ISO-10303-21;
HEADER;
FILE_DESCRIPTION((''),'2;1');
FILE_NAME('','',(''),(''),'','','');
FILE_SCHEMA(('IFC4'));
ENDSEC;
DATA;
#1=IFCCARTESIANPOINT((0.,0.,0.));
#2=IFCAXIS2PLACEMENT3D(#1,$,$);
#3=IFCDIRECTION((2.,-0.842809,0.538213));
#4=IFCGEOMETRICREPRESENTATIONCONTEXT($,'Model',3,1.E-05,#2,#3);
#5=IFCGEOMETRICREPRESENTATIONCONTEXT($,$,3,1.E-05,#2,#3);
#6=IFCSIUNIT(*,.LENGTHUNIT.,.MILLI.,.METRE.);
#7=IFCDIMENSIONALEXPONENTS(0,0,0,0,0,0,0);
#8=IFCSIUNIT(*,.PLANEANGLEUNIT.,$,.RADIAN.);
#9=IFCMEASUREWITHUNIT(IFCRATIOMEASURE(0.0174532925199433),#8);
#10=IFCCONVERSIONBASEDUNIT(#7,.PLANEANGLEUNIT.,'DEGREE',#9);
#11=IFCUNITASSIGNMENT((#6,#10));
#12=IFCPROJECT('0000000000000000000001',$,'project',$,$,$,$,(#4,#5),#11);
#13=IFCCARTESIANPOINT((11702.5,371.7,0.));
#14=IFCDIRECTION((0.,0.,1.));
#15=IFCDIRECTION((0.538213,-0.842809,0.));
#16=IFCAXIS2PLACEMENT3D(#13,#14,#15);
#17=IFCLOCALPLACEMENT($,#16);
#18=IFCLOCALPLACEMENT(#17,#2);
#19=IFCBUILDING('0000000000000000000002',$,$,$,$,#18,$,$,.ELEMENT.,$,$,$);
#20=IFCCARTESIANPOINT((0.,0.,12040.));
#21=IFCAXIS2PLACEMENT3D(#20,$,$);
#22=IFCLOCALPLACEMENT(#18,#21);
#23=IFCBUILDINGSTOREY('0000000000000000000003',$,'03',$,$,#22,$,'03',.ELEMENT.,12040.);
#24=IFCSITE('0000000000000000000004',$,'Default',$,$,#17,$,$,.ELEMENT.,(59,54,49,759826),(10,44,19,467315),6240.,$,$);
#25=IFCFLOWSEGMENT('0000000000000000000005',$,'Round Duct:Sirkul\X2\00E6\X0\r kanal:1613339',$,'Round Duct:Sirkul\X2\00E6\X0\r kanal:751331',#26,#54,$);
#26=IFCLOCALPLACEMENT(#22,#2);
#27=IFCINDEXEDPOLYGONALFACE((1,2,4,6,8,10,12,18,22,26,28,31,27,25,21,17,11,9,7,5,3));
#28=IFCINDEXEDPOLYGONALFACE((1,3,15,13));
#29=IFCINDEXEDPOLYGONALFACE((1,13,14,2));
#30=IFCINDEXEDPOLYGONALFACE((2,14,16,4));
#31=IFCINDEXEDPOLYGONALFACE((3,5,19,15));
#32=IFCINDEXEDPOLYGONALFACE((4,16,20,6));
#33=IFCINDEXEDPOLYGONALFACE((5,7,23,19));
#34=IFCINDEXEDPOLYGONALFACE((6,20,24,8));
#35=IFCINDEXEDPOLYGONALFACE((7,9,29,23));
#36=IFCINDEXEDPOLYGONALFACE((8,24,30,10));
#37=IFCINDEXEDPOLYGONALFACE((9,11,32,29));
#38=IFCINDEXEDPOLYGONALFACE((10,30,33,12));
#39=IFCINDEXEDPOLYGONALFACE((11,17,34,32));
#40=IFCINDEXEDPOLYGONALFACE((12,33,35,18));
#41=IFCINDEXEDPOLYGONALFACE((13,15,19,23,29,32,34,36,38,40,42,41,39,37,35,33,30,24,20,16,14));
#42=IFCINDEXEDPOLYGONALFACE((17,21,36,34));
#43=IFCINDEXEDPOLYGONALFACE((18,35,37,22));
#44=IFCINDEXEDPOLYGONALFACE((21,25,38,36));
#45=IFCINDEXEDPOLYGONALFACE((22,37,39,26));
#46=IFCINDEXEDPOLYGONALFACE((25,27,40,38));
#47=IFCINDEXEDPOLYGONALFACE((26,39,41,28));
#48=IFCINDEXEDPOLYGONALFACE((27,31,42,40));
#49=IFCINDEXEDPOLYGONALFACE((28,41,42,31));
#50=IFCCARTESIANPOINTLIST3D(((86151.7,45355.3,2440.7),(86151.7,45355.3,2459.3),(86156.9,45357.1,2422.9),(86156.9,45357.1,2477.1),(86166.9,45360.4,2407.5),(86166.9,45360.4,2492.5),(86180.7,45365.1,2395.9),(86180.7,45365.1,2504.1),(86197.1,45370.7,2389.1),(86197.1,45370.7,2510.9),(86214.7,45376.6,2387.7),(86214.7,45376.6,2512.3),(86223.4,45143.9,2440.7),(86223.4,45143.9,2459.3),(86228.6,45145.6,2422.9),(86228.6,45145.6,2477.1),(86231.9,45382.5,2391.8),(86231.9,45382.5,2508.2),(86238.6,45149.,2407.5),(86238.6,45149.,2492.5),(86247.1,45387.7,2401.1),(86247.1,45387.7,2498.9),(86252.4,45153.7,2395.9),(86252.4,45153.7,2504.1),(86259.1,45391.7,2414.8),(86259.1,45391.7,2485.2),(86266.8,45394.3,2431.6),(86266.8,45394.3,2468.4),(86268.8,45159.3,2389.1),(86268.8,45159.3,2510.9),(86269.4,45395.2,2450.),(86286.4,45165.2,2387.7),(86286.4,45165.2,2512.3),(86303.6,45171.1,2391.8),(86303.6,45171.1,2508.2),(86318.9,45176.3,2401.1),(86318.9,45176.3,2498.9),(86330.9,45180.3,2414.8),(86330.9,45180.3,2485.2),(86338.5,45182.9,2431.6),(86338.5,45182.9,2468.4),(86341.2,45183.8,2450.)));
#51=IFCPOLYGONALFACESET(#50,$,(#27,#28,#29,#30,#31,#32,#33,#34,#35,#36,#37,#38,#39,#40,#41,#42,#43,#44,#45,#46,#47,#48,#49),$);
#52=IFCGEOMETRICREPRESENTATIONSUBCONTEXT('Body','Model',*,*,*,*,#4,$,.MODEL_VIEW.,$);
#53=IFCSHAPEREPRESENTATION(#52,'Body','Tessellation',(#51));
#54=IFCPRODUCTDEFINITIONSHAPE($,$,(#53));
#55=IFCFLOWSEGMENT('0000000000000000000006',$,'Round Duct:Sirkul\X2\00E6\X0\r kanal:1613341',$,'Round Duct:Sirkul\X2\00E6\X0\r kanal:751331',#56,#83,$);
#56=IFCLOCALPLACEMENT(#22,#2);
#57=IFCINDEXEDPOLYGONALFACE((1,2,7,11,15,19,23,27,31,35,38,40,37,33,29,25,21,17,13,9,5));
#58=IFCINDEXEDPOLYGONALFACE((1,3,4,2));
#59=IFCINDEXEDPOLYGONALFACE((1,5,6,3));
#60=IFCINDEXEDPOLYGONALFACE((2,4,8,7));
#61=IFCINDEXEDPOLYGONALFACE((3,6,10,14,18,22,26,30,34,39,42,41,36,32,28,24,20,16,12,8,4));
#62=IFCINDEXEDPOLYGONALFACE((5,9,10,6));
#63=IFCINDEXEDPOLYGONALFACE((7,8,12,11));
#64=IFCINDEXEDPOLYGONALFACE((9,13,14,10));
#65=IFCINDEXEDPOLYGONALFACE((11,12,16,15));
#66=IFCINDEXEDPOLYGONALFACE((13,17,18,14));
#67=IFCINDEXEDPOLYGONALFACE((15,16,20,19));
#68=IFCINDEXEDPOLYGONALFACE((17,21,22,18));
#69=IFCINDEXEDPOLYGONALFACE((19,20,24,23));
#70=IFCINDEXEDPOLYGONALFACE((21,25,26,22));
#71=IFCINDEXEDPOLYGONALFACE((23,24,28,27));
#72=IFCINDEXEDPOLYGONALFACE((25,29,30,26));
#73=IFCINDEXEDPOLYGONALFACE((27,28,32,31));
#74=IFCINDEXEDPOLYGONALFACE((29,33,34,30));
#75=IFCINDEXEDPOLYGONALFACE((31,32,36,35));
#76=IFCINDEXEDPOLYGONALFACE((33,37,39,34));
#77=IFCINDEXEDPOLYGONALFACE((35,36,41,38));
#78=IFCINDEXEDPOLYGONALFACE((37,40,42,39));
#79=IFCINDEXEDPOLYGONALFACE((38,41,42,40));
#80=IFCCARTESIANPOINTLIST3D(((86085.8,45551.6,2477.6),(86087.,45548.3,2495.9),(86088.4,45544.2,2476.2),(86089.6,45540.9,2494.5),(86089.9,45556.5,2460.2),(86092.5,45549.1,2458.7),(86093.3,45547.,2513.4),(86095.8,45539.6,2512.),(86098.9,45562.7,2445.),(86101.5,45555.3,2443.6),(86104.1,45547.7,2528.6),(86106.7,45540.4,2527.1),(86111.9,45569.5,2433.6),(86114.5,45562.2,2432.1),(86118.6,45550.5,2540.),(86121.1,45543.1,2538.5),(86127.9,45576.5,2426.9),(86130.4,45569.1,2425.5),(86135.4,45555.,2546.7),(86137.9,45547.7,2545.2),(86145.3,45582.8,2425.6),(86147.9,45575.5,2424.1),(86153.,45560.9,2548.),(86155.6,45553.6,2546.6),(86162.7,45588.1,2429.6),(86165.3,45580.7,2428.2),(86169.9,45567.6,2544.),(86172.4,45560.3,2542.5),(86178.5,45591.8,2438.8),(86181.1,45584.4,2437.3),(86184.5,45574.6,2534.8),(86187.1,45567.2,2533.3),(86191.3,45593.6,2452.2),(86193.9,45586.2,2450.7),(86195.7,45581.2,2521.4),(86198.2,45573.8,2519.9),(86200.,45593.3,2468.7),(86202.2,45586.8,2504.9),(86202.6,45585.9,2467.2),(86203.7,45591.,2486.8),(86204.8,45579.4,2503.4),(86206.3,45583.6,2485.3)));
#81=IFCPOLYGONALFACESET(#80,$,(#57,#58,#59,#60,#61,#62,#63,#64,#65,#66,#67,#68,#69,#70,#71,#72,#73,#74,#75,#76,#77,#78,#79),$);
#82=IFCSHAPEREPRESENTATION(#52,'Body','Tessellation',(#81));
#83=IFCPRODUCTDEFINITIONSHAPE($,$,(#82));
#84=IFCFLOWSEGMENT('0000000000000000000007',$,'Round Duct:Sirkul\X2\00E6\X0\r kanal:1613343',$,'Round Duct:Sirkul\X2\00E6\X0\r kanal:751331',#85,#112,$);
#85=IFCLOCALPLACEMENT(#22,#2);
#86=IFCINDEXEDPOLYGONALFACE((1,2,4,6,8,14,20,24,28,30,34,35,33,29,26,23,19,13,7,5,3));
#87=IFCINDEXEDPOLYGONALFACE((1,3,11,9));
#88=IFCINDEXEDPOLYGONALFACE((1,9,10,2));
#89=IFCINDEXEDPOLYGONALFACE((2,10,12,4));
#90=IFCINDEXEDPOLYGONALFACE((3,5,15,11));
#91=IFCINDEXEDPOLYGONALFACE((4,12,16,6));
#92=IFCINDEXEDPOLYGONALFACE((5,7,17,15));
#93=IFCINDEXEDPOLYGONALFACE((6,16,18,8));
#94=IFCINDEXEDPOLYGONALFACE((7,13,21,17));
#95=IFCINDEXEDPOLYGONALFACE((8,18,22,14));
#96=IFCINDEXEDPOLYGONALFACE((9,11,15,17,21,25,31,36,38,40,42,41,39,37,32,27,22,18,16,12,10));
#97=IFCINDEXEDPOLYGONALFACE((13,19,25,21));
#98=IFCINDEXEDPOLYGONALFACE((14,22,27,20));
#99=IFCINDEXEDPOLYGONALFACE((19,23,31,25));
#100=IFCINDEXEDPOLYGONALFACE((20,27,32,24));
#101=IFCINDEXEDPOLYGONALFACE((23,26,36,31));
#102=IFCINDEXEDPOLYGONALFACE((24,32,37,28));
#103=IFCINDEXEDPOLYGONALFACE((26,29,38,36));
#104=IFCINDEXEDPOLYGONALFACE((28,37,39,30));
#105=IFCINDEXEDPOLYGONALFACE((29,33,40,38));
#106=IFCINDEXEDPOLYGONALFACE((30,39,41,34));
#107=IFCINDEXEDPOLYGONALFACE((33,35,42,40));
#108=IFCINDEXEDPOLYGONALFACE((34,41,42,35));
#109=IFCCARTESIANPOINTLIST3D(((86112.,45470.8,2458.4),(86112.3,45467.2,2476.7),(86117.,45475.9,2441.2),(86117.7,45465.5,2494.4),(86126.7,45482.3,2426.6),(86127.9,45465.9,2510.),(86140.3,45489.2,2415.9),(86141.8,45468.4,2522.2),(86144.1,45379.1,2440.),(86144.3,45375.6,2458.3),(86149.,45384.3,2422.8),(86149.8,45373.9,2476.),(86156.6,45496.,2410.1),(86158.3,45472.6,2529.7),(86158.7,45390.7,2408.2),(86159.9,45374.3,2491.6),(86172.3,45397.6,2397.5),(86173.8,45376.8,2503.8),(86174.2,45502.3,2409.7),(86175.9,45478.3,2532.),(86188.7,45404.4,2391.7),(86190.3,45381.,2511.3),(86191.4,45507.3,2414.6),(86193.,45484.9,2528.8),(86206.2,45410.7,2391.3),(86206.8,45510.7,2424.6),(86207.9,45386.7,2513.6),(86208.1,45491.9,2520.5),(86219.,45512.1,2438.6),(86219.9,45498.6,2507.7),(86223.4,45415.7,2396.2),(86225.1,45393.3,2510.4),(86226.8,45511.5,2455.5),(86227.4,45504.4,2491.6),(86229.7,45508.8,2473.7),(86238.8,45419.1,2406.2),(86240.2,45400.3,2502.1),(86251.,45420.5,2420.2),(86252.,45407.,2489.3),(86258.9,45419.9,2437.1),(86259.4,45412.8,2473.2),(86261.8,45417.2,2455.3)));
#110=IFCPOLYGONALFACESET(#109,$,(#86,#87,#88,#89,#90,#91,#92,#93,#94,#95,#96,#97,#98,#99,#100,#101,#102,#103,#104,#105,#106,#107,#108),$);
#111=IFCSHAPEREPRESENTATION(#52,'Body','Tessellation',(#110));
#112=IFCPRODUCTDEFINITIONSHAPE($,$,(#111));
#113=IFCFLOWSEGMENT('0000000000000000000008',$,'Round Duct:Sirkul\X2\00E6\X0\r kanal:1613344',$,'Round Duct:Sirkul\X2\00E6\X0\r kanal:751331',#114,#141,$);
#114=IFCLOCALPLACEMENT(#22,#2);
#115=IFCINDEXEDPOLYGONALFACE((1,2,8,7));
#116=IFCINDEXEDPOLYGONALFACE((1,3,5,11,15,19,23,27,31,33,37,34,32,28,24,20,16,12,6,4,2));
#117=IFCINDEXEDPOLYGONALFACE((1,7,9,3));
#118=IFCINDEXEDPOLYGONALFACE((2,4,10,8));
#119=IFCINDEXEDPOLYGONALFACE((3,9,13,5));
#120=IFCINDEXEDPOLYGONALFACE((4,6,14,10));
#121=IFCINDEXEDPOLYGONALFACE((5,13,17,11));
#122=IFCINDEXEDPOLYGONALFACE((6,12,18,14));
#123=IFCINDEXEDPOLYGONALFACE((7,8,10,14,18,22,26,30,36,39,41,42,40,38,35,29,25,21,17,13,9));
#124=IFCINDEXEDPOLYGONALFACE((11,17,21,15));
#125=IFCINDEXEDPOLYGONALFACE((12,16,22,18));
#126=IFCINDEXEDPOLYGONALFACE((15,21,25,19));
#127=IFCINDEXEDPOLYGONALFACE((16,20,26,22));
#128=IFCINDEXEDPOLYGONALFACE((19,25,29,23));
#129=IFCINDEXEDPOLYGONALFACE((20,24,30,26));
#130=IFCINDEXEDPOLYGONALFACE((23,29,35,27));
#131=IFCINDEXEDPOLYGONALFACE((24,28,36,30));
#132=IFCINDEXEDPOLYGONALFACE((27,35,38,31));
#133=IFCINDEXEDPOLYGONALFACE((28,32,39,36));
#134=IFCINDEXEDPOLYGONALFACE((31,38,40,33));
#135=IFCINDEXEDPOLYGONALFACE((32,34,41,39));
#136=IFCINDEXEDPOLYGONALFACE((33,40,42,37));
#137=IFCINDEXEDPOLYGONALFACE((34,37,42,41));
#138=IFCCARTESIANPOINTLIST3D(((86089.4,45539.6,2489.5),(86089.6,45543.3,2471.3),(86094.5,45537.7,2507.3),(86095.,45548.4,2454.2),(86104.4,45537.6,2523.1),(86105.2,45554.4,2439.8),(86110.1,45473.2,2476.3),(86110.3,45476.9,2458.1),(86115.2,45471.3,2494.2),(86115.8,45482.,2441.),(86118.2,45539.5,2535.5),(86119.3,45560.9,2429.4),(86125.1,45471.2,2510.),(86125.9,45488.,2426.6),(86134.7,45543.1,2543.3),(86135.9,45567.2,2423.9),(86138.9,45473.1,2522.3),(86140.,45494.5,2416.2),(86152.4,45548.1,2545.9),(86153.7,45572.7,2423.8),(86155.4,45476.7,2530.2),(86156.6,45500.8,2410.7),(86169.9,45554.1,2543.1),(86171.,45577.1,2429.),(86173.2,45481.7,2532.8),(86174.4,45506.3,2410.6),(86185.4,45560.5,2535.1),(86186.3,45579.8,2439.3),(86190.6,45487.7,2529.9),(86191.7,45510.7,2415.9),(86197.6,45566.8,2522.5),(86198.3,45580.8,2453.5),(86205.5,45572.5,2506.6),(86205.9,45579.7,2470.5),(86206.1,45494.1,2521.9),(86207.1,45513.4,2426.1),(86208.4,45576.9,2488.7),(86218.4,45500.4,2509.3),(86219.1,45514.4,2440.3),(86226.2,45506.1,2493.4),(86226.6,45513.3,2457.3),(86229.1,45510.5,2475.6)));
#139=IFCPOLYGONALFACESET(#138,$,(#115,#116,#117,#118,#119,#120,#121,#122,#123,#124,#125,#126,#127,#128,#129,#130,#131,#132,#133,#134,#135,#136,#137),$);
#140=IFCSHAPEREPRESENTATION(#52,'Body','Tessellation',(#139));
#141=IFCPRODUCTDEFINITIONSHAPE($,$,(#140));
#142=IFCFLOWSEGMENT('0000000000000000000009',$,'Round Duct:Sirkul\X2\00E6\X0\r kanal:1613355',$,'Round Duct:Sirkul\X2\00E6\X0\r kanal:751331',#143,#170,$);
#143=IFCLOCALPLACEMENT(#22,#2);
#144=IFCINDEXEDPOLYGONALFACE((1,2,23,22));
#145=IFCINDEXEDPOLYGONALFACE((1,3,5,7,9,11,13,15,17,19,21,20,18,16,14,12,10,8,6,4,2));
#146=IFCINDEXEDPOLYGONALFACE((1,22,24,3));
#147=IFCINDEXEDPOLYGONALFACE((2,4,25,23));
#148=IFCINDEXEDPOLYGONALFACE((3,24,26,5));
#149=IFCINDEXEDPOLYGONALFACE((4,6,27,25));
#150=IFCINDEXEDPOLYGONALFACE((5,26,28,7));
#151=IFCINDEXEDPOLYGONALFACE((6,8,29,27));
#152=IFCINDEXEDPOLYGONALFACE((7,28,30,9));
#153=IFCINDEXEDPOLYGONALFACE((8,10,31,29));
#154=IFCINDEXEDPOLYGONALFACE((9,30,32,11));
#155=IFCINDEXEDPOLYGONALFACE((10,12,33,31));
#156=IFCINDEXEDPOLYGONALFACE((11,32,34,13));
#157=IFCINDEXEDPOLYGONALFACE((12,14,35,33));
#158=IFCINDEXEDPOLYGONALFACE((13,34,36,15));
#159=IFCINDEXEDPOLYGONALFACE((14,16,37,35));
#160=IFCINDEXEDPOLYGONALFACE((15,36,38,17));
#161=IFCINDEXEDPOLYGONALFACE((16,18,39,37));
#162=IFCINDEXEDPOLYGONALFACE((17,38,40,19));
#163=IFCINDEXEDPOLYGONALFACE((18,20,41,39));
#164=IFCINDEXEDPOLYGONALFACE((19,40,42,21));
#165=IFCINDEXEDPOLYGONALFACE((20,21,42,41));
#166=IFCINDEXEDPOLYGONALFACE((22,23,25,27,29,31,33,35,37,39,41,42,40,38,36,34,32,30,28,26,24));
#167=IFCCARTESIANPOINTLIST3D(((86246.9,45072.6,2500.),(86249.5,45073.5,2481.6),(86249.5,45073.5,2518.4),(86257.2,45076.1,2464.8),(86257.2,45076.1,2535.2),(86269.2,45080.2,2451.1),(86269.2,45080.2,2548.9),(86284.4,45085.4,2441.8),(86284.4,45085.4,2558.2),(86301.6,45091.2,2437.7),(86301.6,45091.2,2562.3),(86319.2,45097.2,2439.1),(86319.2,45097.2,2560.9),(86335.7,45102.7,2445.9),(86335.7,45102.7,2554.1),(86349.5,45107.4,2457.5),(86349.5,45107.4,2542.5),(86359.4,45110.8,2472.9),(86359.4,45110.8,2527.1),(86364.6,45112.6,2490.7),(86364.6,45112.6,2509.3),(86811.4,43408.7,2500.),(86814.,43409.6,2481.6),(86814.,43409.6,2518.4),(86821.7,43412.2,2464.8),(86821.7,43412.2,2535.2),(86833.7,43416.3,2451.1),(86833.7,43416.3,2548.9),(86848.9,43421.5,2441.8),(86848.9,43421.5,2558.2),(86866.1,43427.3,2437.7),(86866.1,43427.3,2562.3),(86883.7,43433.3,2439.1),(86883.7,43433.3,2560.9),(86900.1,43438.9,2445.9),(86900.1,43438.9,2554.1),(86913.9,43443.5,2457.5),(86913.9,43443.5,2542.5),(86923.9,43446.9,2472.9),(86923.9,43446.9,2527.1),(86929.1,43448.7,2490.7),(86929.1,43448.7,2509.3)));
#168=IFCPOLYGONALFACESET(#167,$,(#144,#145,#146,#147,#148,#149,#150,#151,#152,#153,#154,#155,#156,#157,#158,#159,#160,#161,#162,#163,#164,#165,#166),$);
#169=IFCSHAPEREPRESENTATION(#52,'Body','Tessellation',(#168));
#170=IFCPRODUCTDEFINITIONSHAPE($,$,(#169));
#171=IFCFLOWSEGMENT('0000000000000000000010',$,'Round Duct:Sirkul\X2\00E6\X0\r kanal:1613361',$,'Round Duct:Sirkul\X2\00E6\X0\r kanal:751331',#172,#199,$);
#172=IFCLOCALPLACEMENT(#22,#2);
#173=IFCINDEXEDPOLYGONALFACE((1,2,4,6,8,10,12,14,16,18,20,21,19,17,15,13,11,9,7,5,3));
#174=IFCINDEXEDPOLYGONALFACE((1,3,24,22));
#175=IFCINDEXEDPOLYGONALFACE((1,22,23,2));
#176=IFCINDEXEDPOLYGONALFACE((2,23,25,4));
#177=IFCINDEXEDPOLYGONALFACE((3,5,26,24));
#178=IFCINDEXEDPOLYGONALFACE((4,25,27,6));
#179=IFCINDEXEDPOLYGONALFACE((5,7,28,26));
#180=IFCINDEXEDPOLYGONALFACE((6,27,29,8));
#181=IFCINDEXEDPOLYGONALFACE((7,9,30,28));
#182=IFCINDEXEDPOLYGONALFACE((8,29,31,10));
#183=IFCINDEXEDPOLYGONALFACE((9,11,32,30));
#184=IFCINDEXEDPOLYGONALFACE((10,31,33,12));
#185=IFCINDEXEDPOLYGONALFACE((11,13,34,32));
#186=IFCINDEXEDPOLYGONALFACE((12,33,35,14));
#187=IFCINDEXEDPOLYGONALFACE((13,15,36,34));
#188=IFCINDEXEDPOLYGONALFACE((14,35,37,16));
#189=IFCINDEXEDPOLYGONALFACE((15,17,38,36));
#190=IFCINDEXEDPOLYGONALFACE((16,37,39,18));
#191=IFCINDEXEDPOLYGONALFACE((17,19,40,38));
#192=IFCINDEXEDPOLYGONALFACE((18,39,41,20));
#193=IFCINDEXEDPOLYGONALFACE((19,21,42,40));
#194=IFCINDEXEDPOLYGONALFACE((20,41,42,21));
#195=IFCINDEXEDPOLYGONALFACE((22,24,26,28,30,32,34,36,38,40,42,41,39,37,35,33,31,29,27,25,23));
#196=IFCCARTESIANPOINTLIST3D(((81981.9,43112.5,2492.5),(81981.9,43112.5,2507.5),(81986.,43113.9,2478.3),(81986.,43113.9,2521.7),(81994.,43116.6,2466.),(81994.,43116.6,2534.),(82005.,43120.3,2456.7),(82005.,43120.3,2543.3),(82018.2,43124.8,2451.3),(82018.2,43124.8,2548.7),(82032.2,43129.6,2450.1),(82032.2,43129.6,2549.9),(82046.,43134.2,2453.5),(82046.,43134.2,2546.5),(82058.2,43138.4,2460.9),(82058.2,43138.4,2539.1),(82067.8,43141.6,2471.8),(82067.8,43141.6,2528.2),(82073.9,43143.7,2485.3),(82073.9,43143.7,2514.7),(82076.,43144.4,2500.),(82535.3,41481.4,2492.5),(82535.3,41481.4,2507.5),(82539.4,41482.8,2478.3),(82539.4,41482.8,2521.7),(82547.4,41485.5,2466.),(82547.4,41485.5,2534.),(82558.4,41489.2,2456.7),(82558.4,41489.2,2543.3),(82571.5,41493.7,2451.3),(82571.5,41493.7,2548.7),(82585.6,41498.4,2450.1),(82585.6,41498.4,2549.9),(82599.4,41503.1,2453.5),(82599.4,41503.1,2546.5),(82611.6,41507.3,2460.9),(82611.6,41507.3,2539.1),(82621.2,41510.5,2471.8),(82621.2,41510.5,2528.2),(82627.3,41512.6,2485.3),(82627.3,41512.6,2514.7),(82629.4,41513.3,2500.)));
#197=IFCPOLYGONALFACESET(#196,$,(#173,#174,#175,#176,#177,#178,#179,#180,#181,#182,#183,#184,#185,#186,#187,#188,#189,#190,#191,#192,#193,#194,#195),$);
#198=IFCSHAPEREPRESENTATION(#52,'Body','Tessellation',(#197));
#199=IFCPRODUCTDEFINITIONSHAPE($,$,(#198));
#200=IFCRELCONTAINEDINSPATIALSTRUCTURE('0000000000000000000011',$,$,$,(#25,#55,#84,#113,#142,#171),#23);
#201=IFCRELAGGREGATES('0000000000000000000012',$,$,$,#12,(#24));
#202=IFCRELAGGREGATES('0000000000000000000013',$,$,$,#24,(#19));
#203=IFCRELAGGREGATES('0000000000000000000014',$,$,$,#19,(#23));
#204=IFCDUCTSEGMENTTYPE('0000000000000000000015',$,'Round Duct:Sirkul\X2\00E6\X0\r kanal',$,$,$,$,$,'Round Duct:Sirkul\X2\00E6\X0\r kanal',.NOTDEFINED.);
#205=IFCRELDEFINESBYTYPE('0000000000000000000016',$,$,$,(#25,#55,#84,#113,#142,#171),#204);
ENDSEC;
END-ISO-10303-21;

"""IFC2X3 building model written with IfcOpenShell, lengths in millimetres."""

from ifc_helpers import new_model, entity, si_unit, converted_unit, direction, frame, frame_2d, origin, origin_2d_with_axis, place, context, subcontext, project, spatial, circle, extrude, type_object, element, save


model = new_model("IFC2X3")

# Units and contexts
model_context = context("Model", 3, precision=1e-05, world=origin(), true_north=direction((2.0, -0.842809, 0.538213)))
context_of_model = context(None, 3, precision=1e-05, world=origin(), true_north=direction((2.0, -0.842809, 0.538213)))
body_context = subcontext(model_context, "Body", "Model", "MODEL_VIEW")
ifc_project = project(units=[si_unit("LENGTHUNIT", "METRE", prefix="MILLI"), converted_unit("PLANEANGLEUNIT", "DEGREE", entity("IfcRatioMeasure", 0.0174532925199433), si_unit("PLANEANGLEUNIT", "RADIAN"), dimensions=[0, 0, 0, 0, 0, 0, 0])], contexts=[model_context, context_of_model])

# Site, building, storey
site_placement = place(None, frame((11702.5, 371.7, 0.0), z_axis=(0.0, 0.0, 1.0), x_axis=(0.538213, -0.842809, 0.0)))
site = spatial("IfcSite", under=ifc_project, at=site_placement, Name="Default", CompositionType="ELEMENT", RefLatitude=(59, 54, 49, 759826), RefLongitude=(10, 44, 19, 467315), RefElevation=6240.0)
building_placement = place(site_placement, origin())
building = spatial("IfcBuilding", under=site, at=building_placement, CompositionType="ELEMENT")
storey_placement = place(building_placement, frame((0.0, 0.0, 12040.0)))
storey = spatial("IfcBuildingStorey", under=building, at=storey_placement, Name="03", LongName="03", CompositionType="ELEMENT", Elevation=12040.0)

# Flow segments
duct_segment_type = type_object("IfcDuctSegmentType", Name="Round Duct:Sirkulær kanal", ElementType="Round Duct:Sirkulær kanal", PredefinedType="NOTDEFINED")
flow_segment_1_placement = place(storey_placement, origin())
element("IfcFlowSegment", 1, at=flow_segment_1_placement, inside=storey, type_object=duct_segment_type, Name="Round Duct:Sirkulær kanal:1613339", ObjectType="Round Duct:Sirkulær kanal:751331", context=body_context, shape_type="SweptSolid", body=[
    extrude(circle(Radius=62.5, at=frame_2d((0.0, 0.0), x_axis=(1.0, 0.0))), frame((86282.0, 45163.7, 2450.0), z_axis=(-0.321274, 0.946986, 0.0), x_axis=(0.946986, 0.321274, 0.0)), (0.0, 0.0, 1.0), 223.3),
])
flow_segment_2_placement = place(storey_placement, origin())
element("IfcFlowSegment", 2, at=flow_segment_2_placement, inside=storey, type_object=duct_segment_type, Name="Round Duct:Sirkulær kanal:1613341", ObjectType="Round Duct:Sirkulær kanal:751331", context=body_context, shape_type="SweptSolid", body=[
    extrude(circle(Radius=62.5, at=frame_2d((0.0, 0.0), x_axis=(1.0, 0.0))), frame((86144.7, 45570.3, 2486.8), z_axis=(0.324374, -0.927412, -0.186249), x_axis=(0.943928, 0.33015, 0.0)), (0.0, 0.0, 1.0), 7.9),
])
flow_segment_3_placement = place(storey_placement, origin())
element("IfcFlowSegment", 3, at=flow_segment_3_placement, inside=storey, type_object=duct_segment_type, Name="Round Duct:Sirkulær kanal:1613343", ObjectType="Round Duct:Sirkulær kanal:751331", context=body_context, shape_type="SweptSolid", body=[
    extrude(circle(Radius=62.5, at=origin_2d_with_axis()), frame((86202.7, 45397.2, 2452.2), z_axis=(-0.324374, 0.927412, 0.186249), x_axis=(0.945827, 0.320881, 0.049463)), (0.0, 0.0, 1.0), 98.8),
])
flow_segment_4_placement = place(storey_placement, origin())
element("IfcFlowSegment", 4, at=flow_segment_4_placement, inside=storey, type_object=duct_segment_type, Name="Round Duct:Sirkulær kanal:1613344", ObjectType="Round Duct:Sirkulær kanal:751331", context=body_context, shape_type="SweptSolid", body=[
    extrude(circle(Radius=62.5, at=origin_2d_with_axis()), frame((86169.3, 45492.7, 2471.4), z_axis=(-0.292733, 0.9379, 0.186146), x_axis=(0.06149, -0.175806, 0.982503)), (0.0, 0.0, 1.0), 70.8),
])
flow_segment_5_placement = place(storey_placement, origin())
element("IfcFlowSegment", 5, at=flow_segment_5_placement, inside=storey, type_object=duct_segment_type, Name="Round Duct:Sirkulær kanal:1613355", ObjectType="Round Duct:Sirkulær kanal:751331", context=body_context, shape_type="SweptSolid", body=[
    extrude(circle(Radius=62.5, at=origin_2d_with_axis()), frame((86306.1, 45092.7, 2500.0), z_axis=(0.321274, -0.946986, 0.0), x_axis=(-0.946986, -0.321274, 0.0)), (0.0, 0.0, 1.0), 1757.0),
])
flow_segment_6_placement = place(storey_placement, origin())
element("IfcFlowSegment", 6, at=flow_segment_6_placement, inside=storey, type_object=duct_segment_type, Name="Round Duct:Sirkulær kanal:1613361", ObjectType="Round Duct:Sirkulær kanal:751331", context=body_context, shape_type="SweptSolid", body=[
    extrude(circle(Radius=50.0, at=origin_2d_with_axis()), frame((82582.1, 41497.2, 2500.0), z_axis=(-0.321274, 0.946986, 0.0), x_axis=(0.946986, 0.321274, 0.0)), (0.0, 0.0, 1.0), 1722.5),
])

save(model, "model.ifc")
